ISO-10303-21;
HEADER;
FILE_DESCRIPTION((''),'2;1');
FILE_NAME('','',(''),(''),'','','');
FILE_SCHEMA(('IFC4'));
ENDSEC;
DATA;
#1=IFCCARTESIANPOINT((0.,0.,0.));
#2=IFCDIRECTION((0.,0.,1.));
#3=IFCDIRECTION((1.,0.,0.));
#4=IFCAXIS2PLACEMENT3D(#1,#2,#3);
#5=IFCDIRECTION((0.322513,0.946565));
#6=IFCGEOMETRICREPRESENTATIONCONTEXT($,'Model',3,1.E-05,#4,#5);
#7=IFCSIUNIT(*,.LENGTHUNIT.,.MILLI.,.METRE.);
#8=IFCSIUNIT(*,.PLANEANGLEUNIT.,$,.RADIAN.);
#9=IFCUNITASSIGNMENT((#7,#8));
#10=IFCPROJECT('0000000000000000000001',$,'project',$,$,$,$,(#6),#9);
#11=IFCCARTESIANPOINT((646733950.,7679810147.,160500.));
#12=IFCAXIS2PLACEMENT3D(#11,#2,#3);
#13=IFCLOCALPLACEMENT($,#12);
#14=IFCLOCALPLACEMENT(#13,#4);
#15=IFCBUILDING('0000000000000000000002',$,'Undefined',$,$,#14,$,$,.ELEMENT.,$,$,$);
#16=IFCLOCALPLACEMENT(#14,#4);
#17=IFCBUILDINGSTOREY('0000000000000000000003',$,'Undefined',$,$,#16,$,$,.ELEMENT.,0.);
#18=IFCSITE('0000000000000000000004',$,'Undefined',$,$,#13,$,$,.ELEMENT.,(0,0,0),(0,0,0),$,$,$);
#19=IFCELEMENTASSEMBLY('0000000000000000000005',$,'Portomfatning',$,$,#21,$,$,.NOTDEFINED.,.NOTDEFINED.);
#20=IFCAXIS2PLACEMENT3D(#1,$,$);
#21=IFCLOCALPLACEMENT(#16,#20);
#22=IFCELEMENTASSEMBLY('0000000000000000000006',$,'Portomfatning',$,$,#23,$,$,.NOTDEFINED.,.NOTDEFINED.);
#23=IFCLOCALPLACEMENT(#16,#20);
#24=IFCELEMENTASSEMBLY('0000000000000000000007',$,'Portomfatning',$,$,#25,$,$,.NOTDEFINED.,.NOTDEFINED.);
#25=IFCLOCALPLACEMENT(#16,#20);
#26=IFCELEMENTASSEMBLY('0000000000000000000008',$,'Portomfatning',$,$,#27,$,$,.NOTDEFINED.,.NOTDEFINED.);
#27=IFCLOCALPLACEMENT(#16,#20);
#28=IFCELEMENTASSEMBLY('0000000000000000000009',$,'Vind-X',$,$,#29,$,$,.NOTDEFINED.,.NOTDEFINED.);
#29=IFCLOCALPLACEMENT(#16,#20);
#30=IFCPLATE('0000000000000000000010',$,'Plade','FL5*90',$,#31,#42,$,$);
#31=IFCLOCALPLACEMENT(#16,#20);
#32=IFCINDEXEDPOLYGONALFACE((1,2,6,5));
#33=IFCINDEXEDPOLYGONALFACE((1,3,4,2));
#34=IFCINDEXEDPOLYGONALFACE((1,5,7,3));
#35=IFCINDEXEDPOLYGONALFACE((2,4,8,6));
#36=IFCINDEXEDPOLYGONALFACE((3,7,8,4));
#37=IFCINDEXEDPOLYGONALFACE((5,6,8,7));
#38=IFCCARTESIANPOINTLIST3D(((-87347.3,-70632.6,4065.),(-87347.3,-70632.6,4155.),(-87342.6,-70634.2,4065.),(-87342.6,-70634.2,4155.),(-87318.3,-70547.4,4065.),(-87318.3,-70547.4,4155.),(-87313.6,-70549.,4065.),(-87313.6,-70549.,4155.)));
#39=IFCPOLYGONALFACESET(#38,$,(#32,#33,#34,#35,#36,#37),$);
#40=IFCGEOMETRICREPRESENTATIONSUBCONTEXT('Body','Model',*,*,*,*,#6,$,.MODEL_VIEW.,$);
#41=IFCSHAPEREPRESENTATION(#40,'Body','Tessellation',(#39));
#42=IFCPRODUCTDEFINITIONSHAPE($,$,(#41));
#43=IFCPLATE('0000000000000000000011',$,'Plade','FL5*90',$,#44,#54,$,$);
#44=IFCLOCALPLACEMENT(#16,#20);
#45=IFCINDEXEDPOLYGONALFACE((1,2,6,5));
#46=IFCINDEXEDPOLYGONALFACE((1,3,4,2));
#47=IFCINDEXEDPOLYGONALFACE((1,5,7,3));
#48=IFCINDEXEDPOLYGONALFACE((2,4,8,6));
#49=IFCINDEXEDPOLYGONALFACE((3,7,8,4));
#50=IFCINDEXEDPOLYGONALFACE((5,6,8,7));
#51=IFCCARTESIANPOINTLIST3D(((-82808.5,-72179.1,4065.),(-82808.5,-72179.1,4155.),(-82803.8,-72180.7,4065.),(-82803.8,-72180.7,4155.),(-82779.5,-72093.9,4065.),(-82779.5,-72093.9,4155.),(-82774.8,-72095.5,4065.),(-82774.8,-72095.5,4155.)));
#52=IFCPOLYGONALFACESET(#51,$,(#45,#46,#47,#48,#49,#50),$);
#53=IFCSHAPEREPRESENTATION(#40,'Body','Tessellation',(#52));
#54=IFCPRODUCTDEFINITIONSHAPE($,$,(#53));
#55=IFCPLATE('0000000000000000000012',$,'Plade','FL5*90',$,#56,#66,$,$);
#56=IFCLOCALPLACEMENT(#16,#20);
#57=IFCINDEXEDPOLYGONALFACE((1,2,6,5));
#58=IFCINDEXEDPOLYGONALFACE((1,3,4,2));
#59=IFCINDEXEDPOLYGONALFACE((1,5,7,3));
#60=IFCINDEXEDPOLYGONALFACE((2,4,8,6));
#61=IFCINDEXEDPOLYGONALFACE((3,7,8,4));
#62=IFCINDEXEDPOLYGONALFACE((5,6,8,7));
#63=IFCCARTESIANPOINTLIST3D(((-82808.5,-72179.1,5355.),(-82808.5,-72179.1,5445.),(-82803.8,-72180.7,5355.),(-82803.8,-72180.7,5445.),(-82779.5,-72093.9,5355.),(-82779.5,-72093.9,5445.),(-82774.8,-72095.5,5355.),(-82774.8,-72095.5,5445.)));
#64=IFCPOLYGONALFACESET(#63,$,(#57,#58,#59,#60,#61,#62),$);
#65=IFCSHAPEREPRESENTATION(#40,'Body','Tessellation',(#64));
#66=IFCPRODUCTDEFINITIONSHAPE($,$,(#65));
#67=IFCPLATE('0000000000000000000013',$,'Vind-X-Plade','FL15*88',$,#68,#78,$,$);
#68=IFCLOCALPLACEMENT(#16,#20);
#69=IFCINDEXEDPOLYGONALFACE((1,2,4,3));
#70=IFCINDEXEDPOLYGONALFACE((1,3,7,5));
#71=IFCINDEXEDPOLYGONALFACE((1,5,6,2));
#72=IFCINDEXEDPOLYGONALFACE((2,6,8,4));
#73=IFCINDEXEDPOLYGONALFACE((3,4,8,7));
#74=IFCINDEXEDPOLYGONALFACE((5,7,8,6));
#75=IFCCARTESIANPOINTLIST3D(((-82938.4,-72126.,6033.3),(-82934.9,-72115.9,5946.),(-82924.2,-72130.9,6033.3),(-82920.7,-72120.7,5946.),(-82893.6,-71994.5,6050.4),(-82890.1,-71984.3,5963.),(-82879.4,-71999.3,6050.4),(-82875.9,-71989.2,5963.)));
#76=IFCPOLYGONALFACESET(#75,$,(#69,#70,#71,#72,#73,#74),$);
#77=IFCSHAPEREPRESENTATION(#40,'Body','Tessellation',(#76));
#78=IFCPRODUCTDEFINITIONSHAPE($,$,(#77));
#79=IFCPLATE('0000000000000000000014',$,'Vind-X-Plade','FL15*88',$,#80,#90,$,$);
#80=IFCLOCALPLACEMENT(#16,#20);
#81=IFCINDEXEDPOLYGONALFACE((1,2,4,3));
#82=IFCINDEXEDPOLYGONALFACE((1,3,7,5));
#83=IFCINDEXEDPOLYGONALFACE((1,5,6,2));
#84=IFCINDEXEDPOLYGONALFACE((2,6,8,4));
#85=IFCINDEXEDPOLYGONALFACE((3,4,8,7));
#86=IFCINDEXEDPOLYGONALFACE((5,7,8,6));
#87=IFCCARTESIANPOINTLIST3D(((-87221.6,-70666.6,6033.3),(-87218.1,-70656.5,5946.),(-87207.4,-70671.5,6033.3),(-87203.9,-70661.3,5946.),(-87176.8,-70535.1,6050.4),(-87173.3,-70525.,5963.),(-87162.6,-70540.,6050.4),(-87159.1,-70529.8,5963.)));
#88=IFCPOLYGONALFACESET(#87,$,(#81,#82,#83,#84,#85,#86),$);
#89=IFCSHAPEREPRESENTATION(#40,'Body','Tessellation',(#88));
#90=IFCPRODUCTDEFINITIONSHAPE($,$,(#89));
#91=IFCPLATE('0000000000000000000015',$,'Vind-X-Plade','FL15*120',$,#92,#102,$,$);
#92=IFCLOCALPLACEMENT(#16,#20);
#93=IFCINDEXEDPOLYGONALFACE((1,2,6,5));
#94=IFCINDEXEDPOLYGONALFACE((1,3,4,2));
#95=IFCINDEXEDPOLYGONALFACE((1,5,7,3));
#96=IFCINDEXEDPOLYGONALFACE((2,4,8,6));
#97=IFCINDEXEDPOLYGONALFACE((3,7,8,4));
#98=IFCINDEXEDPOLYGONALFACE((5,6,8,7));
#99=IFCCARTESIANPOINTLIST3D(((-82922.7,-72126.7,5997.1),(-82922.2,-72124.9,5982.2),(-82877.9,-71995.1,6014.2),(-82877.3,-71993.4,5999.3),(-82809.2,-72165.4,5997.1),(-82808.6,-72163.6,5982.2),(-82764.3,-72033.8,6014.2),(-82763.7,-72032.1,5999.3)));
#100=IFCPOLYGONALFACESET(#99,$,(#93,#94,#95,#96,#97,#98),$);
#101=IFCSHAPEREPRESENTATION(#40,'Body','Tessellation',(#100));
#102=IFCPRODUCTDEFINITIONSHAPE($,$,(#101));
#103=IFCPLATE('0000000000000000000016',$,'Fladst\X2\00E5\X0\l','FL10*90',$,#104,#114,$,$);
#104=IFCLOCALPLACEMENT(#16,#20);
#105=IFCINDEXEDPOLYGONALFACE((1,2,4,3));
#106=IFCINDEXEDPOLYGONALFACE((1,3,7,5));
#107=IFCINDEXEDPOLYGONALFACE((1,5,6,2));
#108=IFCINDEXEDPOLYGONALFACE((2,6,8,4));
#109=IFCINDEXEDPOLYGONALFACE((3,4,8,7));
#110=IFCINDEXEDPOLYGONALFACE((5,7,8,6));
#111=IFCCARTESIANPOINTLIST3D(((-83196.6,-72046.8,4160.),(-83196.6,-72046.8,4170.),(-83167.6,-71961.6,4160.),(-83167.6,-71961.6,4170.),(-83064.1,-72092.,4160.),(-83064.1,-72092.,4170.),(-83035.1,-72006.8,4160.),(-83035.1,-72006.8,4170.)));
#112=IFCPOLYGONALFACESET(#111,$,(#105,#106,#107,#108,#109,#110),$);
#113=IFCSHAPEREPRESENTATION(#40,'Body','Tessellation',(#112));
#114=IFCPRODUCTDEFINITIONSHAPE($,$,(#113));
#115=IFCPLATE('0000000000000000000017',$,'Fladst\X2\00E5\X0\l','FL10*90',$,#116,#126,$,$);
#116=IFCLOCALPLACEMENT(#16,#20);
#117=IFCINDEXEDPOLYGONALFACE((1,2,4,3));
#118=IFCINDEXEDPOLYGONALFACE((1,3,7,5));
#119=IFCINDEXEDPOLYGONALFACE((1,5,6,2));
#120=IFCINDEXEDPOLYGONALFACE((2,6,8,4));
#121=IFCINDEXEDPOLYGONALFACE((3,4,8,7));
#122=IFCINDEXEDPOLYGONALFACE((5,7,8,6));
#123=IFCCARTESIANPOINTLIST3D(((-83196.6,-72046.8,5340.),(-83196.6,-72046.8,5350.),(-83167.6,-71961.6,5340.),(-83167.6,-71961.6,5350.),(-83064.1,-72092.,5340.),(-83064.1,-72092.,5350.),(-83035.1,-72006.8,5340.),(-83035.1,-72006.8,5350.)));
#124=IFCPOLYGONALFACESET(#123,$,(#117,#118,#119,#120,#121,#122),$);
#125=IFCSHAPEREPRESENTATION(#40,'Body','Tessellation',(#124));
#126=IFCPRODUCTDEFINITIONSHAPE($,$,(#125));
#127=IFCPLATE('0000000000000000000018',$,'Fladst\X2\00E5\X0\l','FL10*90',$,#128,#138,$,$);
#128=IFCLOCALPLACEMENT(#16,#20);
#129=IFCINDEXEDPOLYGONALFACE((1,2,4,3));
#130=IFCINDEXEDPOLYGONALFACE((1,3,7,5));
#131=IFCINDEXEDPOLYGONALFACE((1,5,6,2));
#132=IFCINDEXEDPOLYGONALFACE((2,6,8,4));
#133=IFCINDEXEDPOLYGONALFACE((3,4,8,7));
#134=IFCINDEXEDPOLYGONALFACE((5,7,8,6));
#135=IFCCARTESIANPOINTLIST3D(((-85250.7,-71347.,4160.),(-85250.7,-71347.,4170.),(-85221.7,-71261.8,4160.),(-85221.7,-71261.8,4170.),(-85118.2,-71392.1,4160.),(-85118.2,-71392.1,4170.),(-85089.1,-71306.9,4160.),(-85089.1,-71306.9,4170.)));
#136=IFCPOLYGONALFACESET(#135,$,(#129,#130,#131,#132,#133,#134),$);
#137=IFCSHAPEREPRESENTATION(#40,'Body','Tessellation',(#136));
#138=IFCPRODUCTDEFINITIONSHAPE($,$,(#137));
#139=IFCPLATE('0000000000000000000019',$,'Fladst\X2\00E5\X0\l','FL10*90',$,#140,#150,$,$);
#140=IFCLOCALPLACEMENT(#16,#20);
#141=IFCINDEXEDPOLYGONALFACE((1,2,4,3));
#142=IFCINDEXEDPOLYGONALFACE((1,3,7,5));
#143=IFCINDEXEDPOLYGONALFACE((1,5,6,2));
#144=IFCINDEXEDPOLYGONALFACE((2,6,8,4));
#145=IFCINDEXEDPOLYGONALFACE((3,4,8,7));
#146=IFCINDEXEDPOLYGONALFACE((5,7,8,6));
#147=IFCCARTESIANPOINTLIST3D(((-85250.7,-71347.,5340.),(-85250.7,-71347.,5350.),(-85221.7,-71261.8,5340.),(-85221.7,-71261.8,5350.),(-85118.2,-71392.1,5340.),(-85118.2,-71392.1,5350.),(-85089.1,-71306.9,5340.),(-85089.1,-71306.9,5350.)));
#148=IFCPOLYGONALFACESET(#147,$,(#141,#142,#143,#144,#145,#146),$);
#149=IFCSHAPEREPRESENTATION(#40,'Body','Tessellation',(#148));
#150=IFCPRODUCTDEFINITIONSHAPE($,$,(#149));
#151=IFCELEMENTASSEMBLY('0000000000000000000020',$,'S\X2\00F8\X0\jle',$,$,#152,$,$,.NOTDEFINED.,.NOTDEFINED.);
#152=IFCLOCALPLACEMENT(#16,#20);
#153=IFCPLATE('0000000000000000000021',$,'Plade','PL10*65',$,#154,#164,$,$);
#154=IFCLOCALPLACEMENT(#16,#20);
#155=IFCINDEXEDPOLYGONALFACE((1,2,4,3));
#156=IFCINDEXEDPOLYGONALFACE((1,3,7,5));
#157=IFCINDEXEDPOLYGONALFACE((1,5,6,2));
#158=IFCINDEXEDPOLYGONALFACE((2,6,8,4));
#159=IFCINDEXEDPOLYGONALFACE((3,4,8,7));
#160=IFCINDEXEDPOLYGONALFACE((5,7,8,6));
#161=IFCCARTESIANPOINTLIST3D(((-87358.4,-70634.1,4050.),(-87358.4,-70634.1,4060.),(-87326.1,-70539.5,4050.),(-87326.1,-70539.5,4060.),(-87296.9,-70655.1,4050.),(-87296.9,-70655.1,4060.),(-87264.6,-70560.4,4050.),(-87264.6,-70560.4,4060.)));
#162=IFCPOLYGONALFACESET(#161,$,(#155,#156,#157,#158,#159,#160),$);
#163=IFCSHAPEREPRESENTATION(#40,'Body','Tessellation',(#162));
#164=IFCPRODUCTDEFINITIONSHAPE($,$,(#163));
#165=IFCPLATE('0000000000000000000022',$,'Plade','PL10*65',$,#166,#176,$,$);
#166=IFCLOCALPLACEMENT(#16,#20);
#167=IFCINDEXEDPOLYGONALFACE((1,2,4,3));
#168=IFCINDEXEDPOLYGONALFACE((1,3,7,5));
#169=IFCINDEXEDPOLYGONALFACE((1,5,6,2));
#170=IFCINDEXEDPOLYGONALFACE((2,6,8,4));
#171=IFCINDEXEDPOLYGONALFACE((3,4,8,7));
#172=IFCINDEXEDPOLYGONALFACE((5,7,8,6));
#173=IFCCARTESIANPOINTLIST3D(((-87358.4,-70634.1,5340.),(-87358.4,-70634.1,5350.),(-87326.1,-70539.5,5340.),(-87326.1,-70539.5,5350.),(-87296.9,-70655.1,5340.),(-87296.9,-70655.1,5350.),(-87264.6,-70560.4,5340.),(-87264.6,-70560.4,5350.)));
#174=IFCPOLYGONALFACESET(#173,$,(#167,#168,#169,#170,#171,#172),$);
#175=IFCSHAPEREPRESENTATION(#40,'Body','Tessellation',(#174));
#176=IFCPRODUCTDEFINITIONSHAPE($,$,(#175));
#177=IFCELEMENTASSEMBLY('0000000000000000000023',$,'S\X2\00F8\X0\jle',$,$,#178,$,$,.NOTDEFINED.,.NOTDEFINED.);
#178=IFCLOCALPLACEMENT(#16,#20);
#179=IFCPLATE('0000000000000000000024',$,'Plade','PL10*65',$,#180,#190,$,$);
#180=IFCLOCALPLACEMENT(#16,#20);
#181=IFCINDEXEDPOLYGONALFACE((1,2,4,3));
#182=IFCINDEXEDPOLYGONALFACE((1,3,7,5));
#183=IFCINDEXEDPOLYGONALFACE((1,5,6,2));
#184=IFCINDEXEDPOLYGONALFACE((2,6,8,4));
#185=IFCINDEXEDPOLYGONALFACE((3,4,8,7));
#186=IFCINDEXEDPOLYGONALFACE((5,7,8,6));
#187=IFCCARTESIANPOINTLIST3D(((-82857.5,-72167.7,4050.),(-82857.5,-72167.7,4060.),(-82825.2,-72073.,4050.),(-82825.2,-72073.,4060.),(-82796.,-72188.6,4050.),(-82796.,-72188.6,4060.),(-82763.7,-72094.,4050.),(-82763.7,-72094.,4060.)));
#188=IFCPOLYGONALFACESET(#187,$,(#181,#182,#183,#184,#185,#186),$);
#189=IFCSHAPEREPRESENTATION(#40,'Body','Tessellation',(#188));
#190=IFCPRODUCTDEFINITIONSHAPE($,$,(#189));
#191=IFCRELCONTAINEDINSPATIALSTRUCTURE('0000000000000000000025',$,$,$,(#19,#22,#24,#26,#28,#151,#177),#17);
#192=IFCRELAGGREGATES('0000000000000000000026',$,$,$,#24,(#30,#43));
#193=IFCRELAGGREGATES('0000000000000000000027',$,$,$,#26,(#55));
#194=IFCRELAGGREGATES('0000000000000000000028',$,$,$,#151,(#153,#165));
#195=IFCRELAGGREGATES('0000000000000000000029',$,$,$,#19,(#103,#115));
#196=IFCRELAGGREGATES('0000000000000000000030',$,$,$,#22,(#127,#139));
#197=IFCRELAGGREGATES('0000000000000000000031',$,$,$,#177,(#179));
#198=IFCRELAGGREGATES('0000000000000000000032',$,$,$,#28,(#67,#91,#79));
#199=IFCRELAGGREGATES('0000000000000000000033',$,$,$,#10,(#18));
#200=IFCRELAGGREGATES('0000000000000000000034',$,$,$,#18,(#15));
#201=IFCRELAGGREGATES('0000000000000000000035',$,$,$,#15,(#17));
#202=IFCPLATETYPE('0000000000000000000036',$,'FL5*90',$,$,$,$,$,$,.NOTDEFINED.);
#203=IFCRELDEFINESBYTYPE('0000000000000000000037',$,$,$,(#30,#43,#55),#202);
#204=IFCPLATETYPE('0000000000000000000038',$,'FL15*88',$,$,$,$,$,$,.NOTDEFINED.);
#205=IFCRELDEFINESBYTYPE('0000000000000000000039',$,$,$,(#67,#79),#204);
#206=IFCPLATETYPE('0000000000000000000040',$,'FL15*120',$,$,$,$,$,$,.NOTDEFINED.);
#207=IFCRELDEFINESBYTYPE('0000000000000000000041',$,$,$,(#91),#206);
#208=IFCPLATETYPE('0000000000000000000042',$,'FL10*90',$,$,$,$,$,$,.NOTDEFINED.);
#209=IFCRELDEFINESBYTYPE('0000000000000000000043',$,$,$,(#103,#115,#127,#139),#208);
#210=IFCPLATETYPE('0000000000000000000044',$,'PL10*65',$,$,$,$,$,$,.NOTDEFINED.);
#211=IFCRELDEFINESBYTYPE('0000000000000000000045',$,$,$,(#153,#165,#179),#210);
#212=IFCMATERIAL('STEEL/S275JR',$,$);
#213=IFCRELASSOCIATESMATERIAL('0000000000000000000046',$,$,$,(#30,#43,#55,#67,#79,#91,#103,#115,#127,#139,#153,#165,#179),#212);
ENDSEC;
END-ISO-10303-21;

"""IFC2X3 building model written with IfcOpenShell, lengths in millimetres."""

from ifc_helpers import new_model, si_unit, direction, frame, origin_with_axes, place, context, subcontext, project, spatial, polyline, outline, extrude, material, type_object, element, aggregate, save


model = new_model("IFC2X3")

# Units and contexts
model_context = context("Model", 3, precision=1e-05, world=origin_with_axes(), true_north=direction((0.322513, 0.946565)))
body_context = subcontext(model_context, "Body", "Model", "MODEL_VIEW")
ifc_project = project(units=[si_unit("LENGTHUNIT", "METRE", prefix="MILLI"), si_unit("PLANEANGLEUNIT", "RADIAN")], contexts=[model_context])

# Site, building, storey
site_placement = place(None, frame((646733950.0, 7679810147.0, 160500.0), z_axis=(0.0, 0.0, 1.0), x_axis=(1.0, 0.0, 0.0)))
site = spatial("IfcSite", under=ifc_project, at=site_placement, Name="Undefined", CompositionType="ELEMENT", RefLatitude=(0, 0, 0), RefLongitude=(0, 0, 0))
building_placement = place(site_placement, origin_with_axes())
building = spatial("IfcBuilding", under=site, at=building_placement, Name="Undefined", CompositionType="ELEMENT")
storey_placement = place(building_placement, origin_with_axes())
storey = spatial("IfcBuildingStorey", under=building, at=storey_placement, Name="Undefined", CompositionType="ELEMENT", Elevation=0.0)

# Element assemblies
assembly_1_placement = place(storey_placement, origin_with_axes())
assembly_1 = element("IfcElementAssembly", 1, at=assembly_1_placement, inside=storey, Name="Portomfatning", AssemblyPlace="NOTDEFINED", PredefinedType="NOTDEFINED")
assembly_2_placement = place(storey_placement, origin_with_axes())
assembly_2 = element("IfcElementAssembly", 2, at=assembly_2_placement, inside=storey, Name="Portomfatning", AssemblyPlace="NOTDEFINED", PredefinedType="NOTDEFINED")

# Element assemblies
assembly_3_placement = place(storey_placement, origin_with_axes())
assembly_3 = element("IfcElementAssembly", 3, at=assembly_3_placement, inside=storey, Name="Portomfatning", AssemblyPlace="NOTDEFINED", PredefinedType="NOTDEFINED")
assembly_4_placement = place(storey_placement, origin_with_axes())
assembly_4 = element("IfcElementAssembly", 4, at=assembly_4_placement, inside=storey, Name="Portomfatning", AssemblyPlace="NOTDEFINED", PredefinedType="NOTDEFINED")
assembly_5_placement = place(storey_placement, origin_with_axes())
assembly_5 = element("IfcElementAssembly", 5, at=assembly_5_placement, inside=storey, Name="Vind-X", AssemblyPlace="NOTDEFINED", PredefinedType="NOTDEFINED")

# Plates
ifc_material_1 = material(Name="STEEL/S275JR")
plate_type_1 = type_object("IfcPlateType", Name="FL5*90", PredefinedType="NOTDEFINED")
plate_1_placement = place(assembly_3_placement, frame((-87345.0, -70633.4, 4065.0), z_axis=(-0.946505, 0.322688, 0.0), x_axis=(0.0, 0.0, 1.0)))
plate_1 = element("IfcPlate", 6, at=plate_1_placement, type_object=plate_type_1, material=ifc_material_1, Name="Plade", Description="FL5*90", context=body_context, shape_type="SweptSolid", body=[
    extrude(outline(polyline([(0.0, 0.0), (90.0, 0.0), (90.0, 90.0), (0.0, 90.0), (0.0, 0.0)])), frame((0.0, 0.0, -2.5), z_axis=(0.0, 0.0, 1.0), x_axis=(1.0, 0.0, 0.0)), (0.0, 0.0, 1.0), 5.0),
])
plate_2_placement = place(assembly_3_placement, frame((-82806.2, -72179.9, 4155.0), z_axis=(0.946625, -0.322338, 0.0), x_axis=(0.0, 0.0, -1.0)))
plate_2 = element("IfcPlate", 7, at=plate_2_placement, type_object=plate_type_1, material=ifc_material_1, Name="Plade", Description="FL5*90", context=body_context, shape_type="SweptSolid", body=[
    extrude(outline(polyline([(0.0, 0.0), (90.0, 0.0), (90.0, 90.0), (0.0, 90.0), (0.0, 0.0)])), frame((0.0, 0.0, -2.5), z_axis=(0.0, 0.0, 1.0), x_axis=(1.0, 0.0, 0.0)), (0.0, 0.0, 1.0), 5.0),
])
aggregate(assembly_3, [plate_1, plate_2])
plate_3_placement = place(assembly_4_placement, frame((-82806.2, -72179.9, 5445.0), z_axis=(0.946625, -0.322338, 0.0), x_axis=(0.0, 0.0, -1.0)))
plate_3 = element("IfcPlate", 8, at=plate_3_placement, type_object=plate_type_1, material=ifc_material_1, Name="Plade", Description="FL5*90", context=body_context, shape_type="SweptSolid", body=[
    extrude(outline(polyline([(0.0, 0.0), (90.0, 0.0), (90.0, 90.0), (0.0, 90.0), (0.0, 0.0)])), frame((0.0, 0.0, -2.5), z_axis=(0.0, 0.0, 1.0), x_axis=(1.0, 0.0, 0.0)), (0.0, 0.0, 1.0), 5.0),
])
aggregate(assembly_4, [plate_3])
plate_type_2 = type_object("IfcPlateType", Name="FL15*88", PredefinedType="NOTDEFINED")
plate_4_placement = place(assembly_5_placement, frame((-82886.5, -71996.9, 6050.4), z_axis=(0.946565, -0.322513, 0.0), x_axis=(-0.320109, -0.93951, -0.121869)))
plate_4 = element("IfcPlate", 9, at=plate_4_placement, type_object=plate_type_2, material=ifc_material_1, Name="Vind-X-Plade", Description="FL15*88", context=body_context, shape_type="SweptSolid", body=[
    extrude(outline(polyline([(0.0, 0.0), (140.0, 0.0), (140.0, 88.0), (0.0, 88.0), (0.0, 0.0)])), frame((0.0, 0.0, -7.5), z_axis=(0.0, 0.0, 1.0), x_axis=(1.0, 0.0, 0.0)), (0.0, 0.0, 1.0), 15.0),
])
plate_5_placement = place(assembly_5_placement, frame((-87214.5, -70669.1, 6033.3), z_axis=(-0.946565, 0.322513, 0.0), x_axis=(0.320109, 0.93951, 0.121869)))
plate_5 = element("IfcPlate", 10, at=plate_5_placement, type_object=plate_type_2, material=ifc_material_1, Name="Vind-X-Plade", Description="FL15*88", context=body_context, shape_type="SweptSolid", body=[
    extrude(outline(polyline([(0.0, 0.0), (140.0, 0.0), (140.0, 88.0), (0.0, 88.0), (0.0, 0.0)])), frame((0.0, 0.0, -7.5), z_axis=(0.0, 0.0, 1.0), x_axis=(1.0, 0.0, 0.0)), (0.0, 0.0, 1.0), 15.0),
])
plate_type_3 = type_object("IfcPlateType", Name="FL15*120", PredefinedType="NOTDEFINED")
plate_6_placement = place(assembly_5_placement, frame((-82786.5, -72098.7, 5998.2), z_axis=(-0.039304, -0.115357, 0.992546), x_axis=(-0.946565, 0.322513, 0.0)))
plate_6 = element("IfcPlate", 11, at=plate_6_placement, type_object=plate_type_3, material=ifc_material_1, Name="Vind-X-Plade", Description="FL15*120", context=body_context, shape_type="SweptSolid", body=[
    extrude(outline(polyline([(0.0, -70.0), (0.0, 70.0), (120.0, 70.0), (120.0, -70.0), (0.0, -70.0)])), frame((0.0, 0.0, -7.5), z_axis=(0.0, 0.0, 1.0), x_axis=(1.0, 0.0, 0.0)), (0.0, 0.0, 1.0), 15.0),
])
plate_type_4 = type_object("IfcPlateType", Name="FL10*90", PredefinedType="NOTDEFINED")
plate_7_placement = place(assembly_1_placement, frame((-83182.1, -72004.2, 4165.0), z_axis=(0.0, 0.0, 1.0), x_axis=(0.946565, -0.322513, 0.0)))
plate_7 = element("IfcPlate", 12, at=plate_7_placement, type_object=plate_type_4, material=ifc_material_1, Name="Fladstål", Description="FL10*90", context=body_context, shape_type="SweptSolid", body=[
    extrude(outline(polyline([(0.0, -45.0), (0.0, 45.0), (140.0, 45.0), (140.0, -45.0), (0.0, -45.0)])), frame((0.0, 0.0, -5.0), z_axis=(0.0, 0.0, 1.0), x_axis=(1.0, 0.0, 0.0)), (0.0, 0.0, 1.0), 10.0),
])
plate_8_placement = place(assembly_1_placement, frame((-83182.1, -72004.2, 5345.0), z_axis=(0.0, 0.0, -1.0), x_axis=(0.946565, -0.322513, 0.0)))
plate_8 = element("IfcPlate", 13, at=plate_8_placement, type_object=plate_type_4, material=ifc_material_1, Name="Fladstål", Description="FL10*90", context=body_context, shape_type="SweptSolid", body=[
    extrude(outline(polyline([(0.0, -45.0), (0.0, 45.0), (140.0, 45.0), (140.0, -45.0), (0.0, -45.0)])), frame((0.0, 0.0, -5.0), z_axis=(0.0, 0.0, 1.0), x_axis=(1.0, 0.0, 0.0)), (0.0, 0.0, 1.0), 10.0),
])
plate_9_placement = place(assembly_2_placement, frame((-85103.6, -71349.5, 4165.0), z_axis=(0.0, 0.0, 1.0), x_axis=(-0.946565, 0.322513, 0.0)))
plate_9 = element("IfcPlate", 14, at=plate_9_placement, type_object=plate_type_4, material=ifc_material_1, Name="Fladstål", Description="FL10*90", context=body_context, shape_type="SweptSolid", body=[
    extrude(outline(polyline([(0.0, -45.0), (0.0, 45.0), (140.0, 45.0), (140.0, -45.0), (0.0, -45.0)])), frame((0.0, 0.0, -5.0), z_axis=(0.0, 0.0, 1.0), x_axis=(1.0, 0.0, 0.0)), (0.0, 0.0, 1.0), 10.0),
])
plate_10_placement = place(assembly_2_placement, frame((-85103.6, -71349.5, 5345.0), z_axis=(0.0, 0.0, -1.0), x_axis=(-0.946565, 0.322513, 0.0)))
plate_10 = element("IfcPlate", 15, at=plate_10_placement, type_object=plate_type_4, material=ifc_material_1, Name="Fladstål", Description="FL10*90", context=body_context, shape_type="SweptSolid", body=[
    extrude(outline(polyline([(0.0, -45.0), (0.0, 45.0), (140.0, 45.0), (140.0, -45.0), (0.0, -45.0)])), frame((0.0, 0.0, -5.0), z_axis=(0.0, 0.0, 1.0), x_axis=(1.0, 0.0, 0.0)), (0.0, 0.0, 1.0), 10.0),
])

# Element assembly, plates
assembly_6_placement = place(storey_placement, origin_with_axes())
assembly_6 = element("IfcElementAssembly", 16, at=assembly_6_placement, inside=storey, Name="Søjle", AssemblyPlace="NOTDEFINED", PredefinedType="NOTDEFINED")
plate_type_5 = type_object("IfcPlateType", Name="PL10*65", PredefinedType="NOTDEFINED")
plate_11_placement = place(assembly_6_placement, frame((-87358.4, -70634.1, 4055.0), z_axis=(0.0, 0.0, 1.0), x_axis=(0.946565, -0.322513, 0.0)))
plate_11 = element("IfcPlate", 17, at=plate_11_placement, type_object=plate_type_5, material=ifc_material_1, Name="Plade", Description="PL10*65", context=body_context, shape_type="SweptSolid", body=[
    extrude(outline(polyline([(0.0, 0.0), (65.0, 0.0), (65.0, 100.0), (0.0, 100.0), (0.0, 0.0)])), frame((0.0, 0.0, -5.0), z_axis=(0.0, 0.0, 1.0), x_axis=(1.0, 0.0, 0.0)), (0.0, 0.0, 1.0), 10.0),
])
plate_12_placement = place(assembly_6_placement, frame((-87358.4, -70634.1, 5345.0), z_axis=(0.0, 0.0, 1.0), x_axis=(0.946565, -0.322513, 0.0)))
plate_12 = element("IfcPlate", 18, at=plate_12_placement, type_object=plate_type_5, material=ifc_material_1, Name="Plade", Description="PL10*65", context=body_context, shape_type="SweptSolid", body=[
    extrude(outline(polyline([(0.0, 0.0), (65.0, 0.0), (65.0, 100.0), (0.0, 100.0), (0.0, 0.0)])), frame((0.0, 0.0, -5.0), z_axis=(0.0, 0.0, 1.0), x_axis=(1.0, 0.0, 0.0)), (0.0, 0.0, 1.0), 10.0),
])
aggregate(assembly_6, [plate_11, plate_12])

# Element assembly, plate
assembly_7_placement = place(storey_placement, origin_with_axes())
assembly_7 = element("IfcElementAssembly", 19, at=assembly_7_placement, inside=storey, Name="Søjle", AssemblyPlace="NOTDEFINED", PredefinedType="NOTDEFINED")
plate_13_placement = place(assembly_7_placement, frame((-82763.7, -72094.0, 4055.0), z_axis=(0.0, 0.0, 1.0), x_axis=(-0.946565, 0.322513, 0.0)))
plate_13 = element("IfcPlate", 20, at=plate_13_placement, type_object=plate_type_5, material=ifc_material_1, Name="Plade", Description="PL10*65", context=body_context, shape_type="SweptSolid", body=[
    extrude(outline(polyline([(0.0, 0.0), (65.0, 0.0), (65.0, 100.0), (0.0, 100.0), (0.0, 0.0)])), frame((0.0, 0.0, -5.0), z_axis=(0.0, 0.0, 1.0), x_axis=(1.0, 0.0, 0.0)), (0.0, 0.0, 1.0), 10.0),
])

aggregate(assembly_1, [plate_7, plate_8])
aggregate(assembly_2, [plate_9, plate_10])
aggregate(assembly_7, [plate_13])
aggregate(assembly_5, [plate_4, plate_6, plate_5])

save(model, "model.ifc")
